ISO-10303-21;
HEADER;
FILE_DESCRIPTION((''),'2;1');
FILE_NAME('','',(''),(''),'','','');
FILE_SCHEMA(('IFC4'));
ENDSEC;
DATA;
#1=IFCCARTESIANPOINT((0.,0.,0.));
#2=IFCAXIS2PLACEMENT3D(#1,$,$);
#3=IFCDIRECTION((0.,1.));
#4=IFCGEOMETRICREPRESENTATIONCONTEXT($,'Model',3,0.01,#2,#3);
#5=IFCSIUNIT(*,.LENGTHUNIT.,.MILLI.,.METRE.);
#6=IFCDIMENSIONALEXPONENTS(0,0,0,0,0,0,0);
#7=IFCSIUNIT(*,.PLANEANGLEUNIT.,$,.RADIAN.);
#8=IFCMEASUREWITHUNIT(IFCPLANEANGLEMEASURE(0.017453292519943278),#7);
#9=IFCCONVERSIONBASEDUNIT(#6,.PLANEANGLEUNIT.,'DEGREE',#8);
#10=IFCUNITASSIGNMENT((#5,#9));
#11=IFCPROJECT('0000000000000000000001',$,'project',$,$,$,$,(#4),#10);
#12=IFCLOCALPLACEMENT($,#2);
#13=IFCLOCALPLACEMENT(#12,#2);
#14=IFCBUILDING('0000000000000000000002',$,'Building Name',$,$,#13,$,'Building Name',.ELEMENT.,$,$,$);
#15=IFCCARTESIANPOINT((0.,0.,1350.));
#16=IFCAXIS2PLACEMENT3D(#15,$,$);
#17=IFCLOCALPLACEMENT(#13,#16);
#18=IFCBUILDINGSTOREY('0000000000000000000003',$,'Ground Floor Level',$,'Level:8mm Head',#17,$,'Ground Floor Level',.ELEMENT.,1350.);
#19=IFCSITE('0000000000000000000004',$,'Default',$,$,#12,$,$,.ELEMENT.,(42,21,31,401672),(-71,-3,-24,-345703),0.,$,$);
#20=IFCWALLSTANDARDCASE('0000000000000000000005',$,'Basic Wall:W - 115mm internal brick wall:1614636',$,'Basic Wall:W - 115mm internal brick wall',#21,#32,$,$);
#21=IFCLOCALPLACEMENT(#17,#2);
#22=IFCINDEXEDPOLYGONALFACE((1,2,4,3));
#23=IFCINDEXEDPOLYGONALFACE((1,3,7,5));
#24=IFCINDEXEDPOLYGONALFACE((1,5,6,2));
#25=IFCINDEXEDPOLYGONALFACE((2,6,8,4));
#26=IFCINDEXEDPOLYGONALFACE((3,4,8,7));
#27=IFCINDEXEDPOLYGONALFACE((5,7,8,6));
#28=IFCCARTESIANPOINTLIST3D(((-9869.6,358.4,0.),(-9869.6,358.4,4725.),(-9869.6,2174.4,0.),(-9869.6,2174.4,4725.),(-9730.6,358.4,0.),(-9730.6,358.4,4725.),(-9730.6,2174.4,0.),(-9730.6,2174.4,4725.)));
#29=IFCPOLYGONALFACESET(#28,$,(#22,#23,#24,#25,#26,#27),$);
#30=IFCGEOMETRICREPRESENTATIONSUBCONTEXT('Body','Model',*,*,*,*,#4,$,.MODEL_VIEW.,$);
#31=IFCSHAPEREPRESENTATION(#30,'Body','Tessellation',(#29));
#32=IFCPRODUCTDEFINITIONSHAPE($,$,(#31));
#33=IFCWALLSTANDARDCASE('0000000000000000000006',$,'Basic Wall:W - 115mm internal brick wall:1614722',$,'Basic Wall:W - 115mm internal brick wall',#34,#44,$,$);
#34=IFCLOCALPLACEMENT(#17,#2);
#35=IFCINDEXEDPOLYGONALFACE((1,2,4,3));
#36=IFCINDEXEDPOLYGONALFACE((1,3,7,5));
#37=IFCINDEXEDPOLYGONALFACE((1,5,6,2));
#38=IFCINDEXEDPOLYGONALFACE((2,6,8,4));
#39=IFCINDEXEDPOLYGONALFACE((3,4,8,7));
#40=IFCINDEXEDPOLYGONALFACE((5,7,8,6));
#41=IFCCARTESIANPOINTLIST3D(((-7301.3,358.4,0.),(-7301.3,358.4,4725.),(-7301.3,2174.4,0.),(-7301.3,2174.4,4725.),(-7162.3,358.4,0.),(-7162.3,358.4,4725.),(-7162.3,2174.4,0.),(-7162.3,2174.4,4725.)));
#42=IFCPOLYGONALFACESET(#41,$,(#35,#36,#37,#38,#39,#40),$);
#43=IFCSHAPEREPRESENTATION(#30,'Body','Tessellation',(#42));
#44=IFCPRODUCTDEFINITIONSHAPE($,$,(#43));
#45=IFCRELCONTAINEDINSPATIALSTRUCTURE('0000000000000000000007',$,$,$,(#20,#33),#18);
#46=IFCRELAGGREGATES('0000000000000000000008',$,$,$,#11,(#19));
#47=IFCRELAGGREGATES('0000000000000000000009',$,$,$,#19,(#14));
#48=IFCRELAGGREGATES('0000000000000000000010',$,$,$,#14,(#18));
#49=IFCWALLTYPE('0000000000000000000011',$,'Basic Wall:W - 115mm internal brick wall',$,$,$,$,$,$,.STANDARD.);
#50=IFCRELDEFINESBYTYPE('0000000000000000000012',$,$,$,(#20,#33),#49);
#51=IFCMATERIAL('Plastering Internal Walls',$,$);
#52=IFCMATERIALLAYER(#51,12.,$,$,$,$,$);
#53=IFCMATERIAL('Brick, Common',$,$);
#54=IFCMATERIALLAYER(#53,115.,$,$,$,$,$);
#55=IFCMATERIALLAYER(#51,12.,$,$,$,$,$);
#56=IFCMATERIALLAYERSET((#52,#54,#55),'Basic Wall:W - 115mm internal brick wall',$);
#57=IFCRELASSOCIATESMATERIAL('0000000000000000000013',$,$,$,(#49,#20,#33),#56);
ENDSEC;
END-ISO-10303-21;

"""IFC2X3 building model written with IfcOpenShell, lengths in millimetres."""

from ifc_helpers import new_model, entity, si_unit, converted_unit, direction, frame, frame_2d, origin, place, context, subcontext, project, spatial, rectangle, extrude, material, layer, layer_set, layer_usage, type_object, element, save


model = new_model("IFC2X3")

# Units and contexts
model_context = context("Model", 3, precision=0.01, world=origin(), true_north=direction((0.0, 1.0)))
body_context = subcontext(model_context, "Body", "Model", "MODEL_VIEW")
ifc_project = project(units=[si_unit("LENGTHUNIT", "METRE", prefix="MILLI"), converted_unit("PLANEANGLEUNIT", "DEGREE", entity("IfcPlaneAngleMeasure", 0.017453292519943278), si_unit("PLANEANGLEUNIT", "RADIAN"), dimensions=[0, 0, 0, 0, 0, 0, 0])], contexts=[model_context])

# Site, building, storey
site_placement = place(None, origin())
site = spatial("IfcSite", under=ifc_project, at=site_placement, Name="Default", CompositionType="ELEMENT", RefLatitude=(42, 21, 31, 401672), RefLongitude=(-71, -3, -24, -345703), RefElevation=0.0)
building_placement = place(site_placement, origin())
building = spatial("IfcBuilding", under=site, at=building_placement, Name="Building Name", LongName="Building Name", CompositionType="ELEMENT")
storey_placement = place(building_placement, frame((0.0, 0.0, 1350.0)))
storey = spatial("IfcBuildingStorey", under=building, at=storey_placement, Name="Ground Floor Level", ObjectType="Level:8mm Head", LongName="Ground Floor Level", CompositionType="ELEMENT", Elevation=1350.0)

# Walls
ifc_material_1 = material(Name="Brick, Common")
ifc_material_2 = material(Name="Plastering Internal Walls")
ifc_layer_1 = layer(ifc_material_2, 12.0)
ifc_layer_2 = layer(ifc_material_1, 115.0)
ifc_layer_3 = layer(ifc_material_2, 12.0)
ifc_layer_set_1 = layer_set([ifc_layer_1, ifc_layer_2, ifc_layer_3], Name="Basic Wall:W - 115mm internal brick wall")
wall_type_1 = type_object("IfcWallType", Name="Basic Wall:W - 115mm internal brick wall", PredefinedType="STANDARD", material=ifc_layer_set_1)
ifc_layer_usage_1 = layer_usage(ifc_layer_set_1, "AXIS2", "NEGATIVE", 69.5)
wall_1_placement = place(storey_placement, frame((-9800.1, 358.4, 0.0), z_axis=(0.0, 0.0, 1.0), x_axis=(0.0, 1.0, 0.0)))
element("IfcWallStandardCase", 1, at=wall_1_placement, inside=storey, type_object=wall_type_1, material=ifc_layer_usage_1, Name="Basic Wall:W - 115mm internal brick wall:1614636", ObjectType="Basic Wall:W - 115mm internal brick wall", context=body_context, shape_type="SweptSolid", body=[
    extrude(rectangle(XDim=1816.0, YDim=139.0, at=frame_2d((908.0, 0.0), x_axis=(-1.0, 0.0))), origin(), (0.0, 0.0, 1.0), 4725.0),
])
ifc_layer_usage_2 = layer_usage(ifc_layer_set_1, "AXIS2", "NEGATIVE", 69.5)
wall_2_placement = place(storey_placement, frame((-7231.8, 358.4, 0.0), z_axis=(0.0, 0.0, 1.0), x_axis=(0.0, 1.0, 0.0)))
element("IfcWallStandardCase", 2, at=wall_2_placement, inside=storey, type_object=wall_type_1, material=ifc_layer_usage_2, Name="Basic Wall:W - 115mm internal brick wall:1614722", ObjectType="Basic Wall:W - 115mm internal brick wall", context=body_context, shape_type="SweptSolid", body=[
    extrude(rectangle(XDim=1816.0, YDim=139.0, at=frame_2d((908.0, 0.0), x_axis=(-1.0, 0.0))), origin(), (0.0, 0.0, 1.0), 4725.0),
])

save(model, "model.ifc")
